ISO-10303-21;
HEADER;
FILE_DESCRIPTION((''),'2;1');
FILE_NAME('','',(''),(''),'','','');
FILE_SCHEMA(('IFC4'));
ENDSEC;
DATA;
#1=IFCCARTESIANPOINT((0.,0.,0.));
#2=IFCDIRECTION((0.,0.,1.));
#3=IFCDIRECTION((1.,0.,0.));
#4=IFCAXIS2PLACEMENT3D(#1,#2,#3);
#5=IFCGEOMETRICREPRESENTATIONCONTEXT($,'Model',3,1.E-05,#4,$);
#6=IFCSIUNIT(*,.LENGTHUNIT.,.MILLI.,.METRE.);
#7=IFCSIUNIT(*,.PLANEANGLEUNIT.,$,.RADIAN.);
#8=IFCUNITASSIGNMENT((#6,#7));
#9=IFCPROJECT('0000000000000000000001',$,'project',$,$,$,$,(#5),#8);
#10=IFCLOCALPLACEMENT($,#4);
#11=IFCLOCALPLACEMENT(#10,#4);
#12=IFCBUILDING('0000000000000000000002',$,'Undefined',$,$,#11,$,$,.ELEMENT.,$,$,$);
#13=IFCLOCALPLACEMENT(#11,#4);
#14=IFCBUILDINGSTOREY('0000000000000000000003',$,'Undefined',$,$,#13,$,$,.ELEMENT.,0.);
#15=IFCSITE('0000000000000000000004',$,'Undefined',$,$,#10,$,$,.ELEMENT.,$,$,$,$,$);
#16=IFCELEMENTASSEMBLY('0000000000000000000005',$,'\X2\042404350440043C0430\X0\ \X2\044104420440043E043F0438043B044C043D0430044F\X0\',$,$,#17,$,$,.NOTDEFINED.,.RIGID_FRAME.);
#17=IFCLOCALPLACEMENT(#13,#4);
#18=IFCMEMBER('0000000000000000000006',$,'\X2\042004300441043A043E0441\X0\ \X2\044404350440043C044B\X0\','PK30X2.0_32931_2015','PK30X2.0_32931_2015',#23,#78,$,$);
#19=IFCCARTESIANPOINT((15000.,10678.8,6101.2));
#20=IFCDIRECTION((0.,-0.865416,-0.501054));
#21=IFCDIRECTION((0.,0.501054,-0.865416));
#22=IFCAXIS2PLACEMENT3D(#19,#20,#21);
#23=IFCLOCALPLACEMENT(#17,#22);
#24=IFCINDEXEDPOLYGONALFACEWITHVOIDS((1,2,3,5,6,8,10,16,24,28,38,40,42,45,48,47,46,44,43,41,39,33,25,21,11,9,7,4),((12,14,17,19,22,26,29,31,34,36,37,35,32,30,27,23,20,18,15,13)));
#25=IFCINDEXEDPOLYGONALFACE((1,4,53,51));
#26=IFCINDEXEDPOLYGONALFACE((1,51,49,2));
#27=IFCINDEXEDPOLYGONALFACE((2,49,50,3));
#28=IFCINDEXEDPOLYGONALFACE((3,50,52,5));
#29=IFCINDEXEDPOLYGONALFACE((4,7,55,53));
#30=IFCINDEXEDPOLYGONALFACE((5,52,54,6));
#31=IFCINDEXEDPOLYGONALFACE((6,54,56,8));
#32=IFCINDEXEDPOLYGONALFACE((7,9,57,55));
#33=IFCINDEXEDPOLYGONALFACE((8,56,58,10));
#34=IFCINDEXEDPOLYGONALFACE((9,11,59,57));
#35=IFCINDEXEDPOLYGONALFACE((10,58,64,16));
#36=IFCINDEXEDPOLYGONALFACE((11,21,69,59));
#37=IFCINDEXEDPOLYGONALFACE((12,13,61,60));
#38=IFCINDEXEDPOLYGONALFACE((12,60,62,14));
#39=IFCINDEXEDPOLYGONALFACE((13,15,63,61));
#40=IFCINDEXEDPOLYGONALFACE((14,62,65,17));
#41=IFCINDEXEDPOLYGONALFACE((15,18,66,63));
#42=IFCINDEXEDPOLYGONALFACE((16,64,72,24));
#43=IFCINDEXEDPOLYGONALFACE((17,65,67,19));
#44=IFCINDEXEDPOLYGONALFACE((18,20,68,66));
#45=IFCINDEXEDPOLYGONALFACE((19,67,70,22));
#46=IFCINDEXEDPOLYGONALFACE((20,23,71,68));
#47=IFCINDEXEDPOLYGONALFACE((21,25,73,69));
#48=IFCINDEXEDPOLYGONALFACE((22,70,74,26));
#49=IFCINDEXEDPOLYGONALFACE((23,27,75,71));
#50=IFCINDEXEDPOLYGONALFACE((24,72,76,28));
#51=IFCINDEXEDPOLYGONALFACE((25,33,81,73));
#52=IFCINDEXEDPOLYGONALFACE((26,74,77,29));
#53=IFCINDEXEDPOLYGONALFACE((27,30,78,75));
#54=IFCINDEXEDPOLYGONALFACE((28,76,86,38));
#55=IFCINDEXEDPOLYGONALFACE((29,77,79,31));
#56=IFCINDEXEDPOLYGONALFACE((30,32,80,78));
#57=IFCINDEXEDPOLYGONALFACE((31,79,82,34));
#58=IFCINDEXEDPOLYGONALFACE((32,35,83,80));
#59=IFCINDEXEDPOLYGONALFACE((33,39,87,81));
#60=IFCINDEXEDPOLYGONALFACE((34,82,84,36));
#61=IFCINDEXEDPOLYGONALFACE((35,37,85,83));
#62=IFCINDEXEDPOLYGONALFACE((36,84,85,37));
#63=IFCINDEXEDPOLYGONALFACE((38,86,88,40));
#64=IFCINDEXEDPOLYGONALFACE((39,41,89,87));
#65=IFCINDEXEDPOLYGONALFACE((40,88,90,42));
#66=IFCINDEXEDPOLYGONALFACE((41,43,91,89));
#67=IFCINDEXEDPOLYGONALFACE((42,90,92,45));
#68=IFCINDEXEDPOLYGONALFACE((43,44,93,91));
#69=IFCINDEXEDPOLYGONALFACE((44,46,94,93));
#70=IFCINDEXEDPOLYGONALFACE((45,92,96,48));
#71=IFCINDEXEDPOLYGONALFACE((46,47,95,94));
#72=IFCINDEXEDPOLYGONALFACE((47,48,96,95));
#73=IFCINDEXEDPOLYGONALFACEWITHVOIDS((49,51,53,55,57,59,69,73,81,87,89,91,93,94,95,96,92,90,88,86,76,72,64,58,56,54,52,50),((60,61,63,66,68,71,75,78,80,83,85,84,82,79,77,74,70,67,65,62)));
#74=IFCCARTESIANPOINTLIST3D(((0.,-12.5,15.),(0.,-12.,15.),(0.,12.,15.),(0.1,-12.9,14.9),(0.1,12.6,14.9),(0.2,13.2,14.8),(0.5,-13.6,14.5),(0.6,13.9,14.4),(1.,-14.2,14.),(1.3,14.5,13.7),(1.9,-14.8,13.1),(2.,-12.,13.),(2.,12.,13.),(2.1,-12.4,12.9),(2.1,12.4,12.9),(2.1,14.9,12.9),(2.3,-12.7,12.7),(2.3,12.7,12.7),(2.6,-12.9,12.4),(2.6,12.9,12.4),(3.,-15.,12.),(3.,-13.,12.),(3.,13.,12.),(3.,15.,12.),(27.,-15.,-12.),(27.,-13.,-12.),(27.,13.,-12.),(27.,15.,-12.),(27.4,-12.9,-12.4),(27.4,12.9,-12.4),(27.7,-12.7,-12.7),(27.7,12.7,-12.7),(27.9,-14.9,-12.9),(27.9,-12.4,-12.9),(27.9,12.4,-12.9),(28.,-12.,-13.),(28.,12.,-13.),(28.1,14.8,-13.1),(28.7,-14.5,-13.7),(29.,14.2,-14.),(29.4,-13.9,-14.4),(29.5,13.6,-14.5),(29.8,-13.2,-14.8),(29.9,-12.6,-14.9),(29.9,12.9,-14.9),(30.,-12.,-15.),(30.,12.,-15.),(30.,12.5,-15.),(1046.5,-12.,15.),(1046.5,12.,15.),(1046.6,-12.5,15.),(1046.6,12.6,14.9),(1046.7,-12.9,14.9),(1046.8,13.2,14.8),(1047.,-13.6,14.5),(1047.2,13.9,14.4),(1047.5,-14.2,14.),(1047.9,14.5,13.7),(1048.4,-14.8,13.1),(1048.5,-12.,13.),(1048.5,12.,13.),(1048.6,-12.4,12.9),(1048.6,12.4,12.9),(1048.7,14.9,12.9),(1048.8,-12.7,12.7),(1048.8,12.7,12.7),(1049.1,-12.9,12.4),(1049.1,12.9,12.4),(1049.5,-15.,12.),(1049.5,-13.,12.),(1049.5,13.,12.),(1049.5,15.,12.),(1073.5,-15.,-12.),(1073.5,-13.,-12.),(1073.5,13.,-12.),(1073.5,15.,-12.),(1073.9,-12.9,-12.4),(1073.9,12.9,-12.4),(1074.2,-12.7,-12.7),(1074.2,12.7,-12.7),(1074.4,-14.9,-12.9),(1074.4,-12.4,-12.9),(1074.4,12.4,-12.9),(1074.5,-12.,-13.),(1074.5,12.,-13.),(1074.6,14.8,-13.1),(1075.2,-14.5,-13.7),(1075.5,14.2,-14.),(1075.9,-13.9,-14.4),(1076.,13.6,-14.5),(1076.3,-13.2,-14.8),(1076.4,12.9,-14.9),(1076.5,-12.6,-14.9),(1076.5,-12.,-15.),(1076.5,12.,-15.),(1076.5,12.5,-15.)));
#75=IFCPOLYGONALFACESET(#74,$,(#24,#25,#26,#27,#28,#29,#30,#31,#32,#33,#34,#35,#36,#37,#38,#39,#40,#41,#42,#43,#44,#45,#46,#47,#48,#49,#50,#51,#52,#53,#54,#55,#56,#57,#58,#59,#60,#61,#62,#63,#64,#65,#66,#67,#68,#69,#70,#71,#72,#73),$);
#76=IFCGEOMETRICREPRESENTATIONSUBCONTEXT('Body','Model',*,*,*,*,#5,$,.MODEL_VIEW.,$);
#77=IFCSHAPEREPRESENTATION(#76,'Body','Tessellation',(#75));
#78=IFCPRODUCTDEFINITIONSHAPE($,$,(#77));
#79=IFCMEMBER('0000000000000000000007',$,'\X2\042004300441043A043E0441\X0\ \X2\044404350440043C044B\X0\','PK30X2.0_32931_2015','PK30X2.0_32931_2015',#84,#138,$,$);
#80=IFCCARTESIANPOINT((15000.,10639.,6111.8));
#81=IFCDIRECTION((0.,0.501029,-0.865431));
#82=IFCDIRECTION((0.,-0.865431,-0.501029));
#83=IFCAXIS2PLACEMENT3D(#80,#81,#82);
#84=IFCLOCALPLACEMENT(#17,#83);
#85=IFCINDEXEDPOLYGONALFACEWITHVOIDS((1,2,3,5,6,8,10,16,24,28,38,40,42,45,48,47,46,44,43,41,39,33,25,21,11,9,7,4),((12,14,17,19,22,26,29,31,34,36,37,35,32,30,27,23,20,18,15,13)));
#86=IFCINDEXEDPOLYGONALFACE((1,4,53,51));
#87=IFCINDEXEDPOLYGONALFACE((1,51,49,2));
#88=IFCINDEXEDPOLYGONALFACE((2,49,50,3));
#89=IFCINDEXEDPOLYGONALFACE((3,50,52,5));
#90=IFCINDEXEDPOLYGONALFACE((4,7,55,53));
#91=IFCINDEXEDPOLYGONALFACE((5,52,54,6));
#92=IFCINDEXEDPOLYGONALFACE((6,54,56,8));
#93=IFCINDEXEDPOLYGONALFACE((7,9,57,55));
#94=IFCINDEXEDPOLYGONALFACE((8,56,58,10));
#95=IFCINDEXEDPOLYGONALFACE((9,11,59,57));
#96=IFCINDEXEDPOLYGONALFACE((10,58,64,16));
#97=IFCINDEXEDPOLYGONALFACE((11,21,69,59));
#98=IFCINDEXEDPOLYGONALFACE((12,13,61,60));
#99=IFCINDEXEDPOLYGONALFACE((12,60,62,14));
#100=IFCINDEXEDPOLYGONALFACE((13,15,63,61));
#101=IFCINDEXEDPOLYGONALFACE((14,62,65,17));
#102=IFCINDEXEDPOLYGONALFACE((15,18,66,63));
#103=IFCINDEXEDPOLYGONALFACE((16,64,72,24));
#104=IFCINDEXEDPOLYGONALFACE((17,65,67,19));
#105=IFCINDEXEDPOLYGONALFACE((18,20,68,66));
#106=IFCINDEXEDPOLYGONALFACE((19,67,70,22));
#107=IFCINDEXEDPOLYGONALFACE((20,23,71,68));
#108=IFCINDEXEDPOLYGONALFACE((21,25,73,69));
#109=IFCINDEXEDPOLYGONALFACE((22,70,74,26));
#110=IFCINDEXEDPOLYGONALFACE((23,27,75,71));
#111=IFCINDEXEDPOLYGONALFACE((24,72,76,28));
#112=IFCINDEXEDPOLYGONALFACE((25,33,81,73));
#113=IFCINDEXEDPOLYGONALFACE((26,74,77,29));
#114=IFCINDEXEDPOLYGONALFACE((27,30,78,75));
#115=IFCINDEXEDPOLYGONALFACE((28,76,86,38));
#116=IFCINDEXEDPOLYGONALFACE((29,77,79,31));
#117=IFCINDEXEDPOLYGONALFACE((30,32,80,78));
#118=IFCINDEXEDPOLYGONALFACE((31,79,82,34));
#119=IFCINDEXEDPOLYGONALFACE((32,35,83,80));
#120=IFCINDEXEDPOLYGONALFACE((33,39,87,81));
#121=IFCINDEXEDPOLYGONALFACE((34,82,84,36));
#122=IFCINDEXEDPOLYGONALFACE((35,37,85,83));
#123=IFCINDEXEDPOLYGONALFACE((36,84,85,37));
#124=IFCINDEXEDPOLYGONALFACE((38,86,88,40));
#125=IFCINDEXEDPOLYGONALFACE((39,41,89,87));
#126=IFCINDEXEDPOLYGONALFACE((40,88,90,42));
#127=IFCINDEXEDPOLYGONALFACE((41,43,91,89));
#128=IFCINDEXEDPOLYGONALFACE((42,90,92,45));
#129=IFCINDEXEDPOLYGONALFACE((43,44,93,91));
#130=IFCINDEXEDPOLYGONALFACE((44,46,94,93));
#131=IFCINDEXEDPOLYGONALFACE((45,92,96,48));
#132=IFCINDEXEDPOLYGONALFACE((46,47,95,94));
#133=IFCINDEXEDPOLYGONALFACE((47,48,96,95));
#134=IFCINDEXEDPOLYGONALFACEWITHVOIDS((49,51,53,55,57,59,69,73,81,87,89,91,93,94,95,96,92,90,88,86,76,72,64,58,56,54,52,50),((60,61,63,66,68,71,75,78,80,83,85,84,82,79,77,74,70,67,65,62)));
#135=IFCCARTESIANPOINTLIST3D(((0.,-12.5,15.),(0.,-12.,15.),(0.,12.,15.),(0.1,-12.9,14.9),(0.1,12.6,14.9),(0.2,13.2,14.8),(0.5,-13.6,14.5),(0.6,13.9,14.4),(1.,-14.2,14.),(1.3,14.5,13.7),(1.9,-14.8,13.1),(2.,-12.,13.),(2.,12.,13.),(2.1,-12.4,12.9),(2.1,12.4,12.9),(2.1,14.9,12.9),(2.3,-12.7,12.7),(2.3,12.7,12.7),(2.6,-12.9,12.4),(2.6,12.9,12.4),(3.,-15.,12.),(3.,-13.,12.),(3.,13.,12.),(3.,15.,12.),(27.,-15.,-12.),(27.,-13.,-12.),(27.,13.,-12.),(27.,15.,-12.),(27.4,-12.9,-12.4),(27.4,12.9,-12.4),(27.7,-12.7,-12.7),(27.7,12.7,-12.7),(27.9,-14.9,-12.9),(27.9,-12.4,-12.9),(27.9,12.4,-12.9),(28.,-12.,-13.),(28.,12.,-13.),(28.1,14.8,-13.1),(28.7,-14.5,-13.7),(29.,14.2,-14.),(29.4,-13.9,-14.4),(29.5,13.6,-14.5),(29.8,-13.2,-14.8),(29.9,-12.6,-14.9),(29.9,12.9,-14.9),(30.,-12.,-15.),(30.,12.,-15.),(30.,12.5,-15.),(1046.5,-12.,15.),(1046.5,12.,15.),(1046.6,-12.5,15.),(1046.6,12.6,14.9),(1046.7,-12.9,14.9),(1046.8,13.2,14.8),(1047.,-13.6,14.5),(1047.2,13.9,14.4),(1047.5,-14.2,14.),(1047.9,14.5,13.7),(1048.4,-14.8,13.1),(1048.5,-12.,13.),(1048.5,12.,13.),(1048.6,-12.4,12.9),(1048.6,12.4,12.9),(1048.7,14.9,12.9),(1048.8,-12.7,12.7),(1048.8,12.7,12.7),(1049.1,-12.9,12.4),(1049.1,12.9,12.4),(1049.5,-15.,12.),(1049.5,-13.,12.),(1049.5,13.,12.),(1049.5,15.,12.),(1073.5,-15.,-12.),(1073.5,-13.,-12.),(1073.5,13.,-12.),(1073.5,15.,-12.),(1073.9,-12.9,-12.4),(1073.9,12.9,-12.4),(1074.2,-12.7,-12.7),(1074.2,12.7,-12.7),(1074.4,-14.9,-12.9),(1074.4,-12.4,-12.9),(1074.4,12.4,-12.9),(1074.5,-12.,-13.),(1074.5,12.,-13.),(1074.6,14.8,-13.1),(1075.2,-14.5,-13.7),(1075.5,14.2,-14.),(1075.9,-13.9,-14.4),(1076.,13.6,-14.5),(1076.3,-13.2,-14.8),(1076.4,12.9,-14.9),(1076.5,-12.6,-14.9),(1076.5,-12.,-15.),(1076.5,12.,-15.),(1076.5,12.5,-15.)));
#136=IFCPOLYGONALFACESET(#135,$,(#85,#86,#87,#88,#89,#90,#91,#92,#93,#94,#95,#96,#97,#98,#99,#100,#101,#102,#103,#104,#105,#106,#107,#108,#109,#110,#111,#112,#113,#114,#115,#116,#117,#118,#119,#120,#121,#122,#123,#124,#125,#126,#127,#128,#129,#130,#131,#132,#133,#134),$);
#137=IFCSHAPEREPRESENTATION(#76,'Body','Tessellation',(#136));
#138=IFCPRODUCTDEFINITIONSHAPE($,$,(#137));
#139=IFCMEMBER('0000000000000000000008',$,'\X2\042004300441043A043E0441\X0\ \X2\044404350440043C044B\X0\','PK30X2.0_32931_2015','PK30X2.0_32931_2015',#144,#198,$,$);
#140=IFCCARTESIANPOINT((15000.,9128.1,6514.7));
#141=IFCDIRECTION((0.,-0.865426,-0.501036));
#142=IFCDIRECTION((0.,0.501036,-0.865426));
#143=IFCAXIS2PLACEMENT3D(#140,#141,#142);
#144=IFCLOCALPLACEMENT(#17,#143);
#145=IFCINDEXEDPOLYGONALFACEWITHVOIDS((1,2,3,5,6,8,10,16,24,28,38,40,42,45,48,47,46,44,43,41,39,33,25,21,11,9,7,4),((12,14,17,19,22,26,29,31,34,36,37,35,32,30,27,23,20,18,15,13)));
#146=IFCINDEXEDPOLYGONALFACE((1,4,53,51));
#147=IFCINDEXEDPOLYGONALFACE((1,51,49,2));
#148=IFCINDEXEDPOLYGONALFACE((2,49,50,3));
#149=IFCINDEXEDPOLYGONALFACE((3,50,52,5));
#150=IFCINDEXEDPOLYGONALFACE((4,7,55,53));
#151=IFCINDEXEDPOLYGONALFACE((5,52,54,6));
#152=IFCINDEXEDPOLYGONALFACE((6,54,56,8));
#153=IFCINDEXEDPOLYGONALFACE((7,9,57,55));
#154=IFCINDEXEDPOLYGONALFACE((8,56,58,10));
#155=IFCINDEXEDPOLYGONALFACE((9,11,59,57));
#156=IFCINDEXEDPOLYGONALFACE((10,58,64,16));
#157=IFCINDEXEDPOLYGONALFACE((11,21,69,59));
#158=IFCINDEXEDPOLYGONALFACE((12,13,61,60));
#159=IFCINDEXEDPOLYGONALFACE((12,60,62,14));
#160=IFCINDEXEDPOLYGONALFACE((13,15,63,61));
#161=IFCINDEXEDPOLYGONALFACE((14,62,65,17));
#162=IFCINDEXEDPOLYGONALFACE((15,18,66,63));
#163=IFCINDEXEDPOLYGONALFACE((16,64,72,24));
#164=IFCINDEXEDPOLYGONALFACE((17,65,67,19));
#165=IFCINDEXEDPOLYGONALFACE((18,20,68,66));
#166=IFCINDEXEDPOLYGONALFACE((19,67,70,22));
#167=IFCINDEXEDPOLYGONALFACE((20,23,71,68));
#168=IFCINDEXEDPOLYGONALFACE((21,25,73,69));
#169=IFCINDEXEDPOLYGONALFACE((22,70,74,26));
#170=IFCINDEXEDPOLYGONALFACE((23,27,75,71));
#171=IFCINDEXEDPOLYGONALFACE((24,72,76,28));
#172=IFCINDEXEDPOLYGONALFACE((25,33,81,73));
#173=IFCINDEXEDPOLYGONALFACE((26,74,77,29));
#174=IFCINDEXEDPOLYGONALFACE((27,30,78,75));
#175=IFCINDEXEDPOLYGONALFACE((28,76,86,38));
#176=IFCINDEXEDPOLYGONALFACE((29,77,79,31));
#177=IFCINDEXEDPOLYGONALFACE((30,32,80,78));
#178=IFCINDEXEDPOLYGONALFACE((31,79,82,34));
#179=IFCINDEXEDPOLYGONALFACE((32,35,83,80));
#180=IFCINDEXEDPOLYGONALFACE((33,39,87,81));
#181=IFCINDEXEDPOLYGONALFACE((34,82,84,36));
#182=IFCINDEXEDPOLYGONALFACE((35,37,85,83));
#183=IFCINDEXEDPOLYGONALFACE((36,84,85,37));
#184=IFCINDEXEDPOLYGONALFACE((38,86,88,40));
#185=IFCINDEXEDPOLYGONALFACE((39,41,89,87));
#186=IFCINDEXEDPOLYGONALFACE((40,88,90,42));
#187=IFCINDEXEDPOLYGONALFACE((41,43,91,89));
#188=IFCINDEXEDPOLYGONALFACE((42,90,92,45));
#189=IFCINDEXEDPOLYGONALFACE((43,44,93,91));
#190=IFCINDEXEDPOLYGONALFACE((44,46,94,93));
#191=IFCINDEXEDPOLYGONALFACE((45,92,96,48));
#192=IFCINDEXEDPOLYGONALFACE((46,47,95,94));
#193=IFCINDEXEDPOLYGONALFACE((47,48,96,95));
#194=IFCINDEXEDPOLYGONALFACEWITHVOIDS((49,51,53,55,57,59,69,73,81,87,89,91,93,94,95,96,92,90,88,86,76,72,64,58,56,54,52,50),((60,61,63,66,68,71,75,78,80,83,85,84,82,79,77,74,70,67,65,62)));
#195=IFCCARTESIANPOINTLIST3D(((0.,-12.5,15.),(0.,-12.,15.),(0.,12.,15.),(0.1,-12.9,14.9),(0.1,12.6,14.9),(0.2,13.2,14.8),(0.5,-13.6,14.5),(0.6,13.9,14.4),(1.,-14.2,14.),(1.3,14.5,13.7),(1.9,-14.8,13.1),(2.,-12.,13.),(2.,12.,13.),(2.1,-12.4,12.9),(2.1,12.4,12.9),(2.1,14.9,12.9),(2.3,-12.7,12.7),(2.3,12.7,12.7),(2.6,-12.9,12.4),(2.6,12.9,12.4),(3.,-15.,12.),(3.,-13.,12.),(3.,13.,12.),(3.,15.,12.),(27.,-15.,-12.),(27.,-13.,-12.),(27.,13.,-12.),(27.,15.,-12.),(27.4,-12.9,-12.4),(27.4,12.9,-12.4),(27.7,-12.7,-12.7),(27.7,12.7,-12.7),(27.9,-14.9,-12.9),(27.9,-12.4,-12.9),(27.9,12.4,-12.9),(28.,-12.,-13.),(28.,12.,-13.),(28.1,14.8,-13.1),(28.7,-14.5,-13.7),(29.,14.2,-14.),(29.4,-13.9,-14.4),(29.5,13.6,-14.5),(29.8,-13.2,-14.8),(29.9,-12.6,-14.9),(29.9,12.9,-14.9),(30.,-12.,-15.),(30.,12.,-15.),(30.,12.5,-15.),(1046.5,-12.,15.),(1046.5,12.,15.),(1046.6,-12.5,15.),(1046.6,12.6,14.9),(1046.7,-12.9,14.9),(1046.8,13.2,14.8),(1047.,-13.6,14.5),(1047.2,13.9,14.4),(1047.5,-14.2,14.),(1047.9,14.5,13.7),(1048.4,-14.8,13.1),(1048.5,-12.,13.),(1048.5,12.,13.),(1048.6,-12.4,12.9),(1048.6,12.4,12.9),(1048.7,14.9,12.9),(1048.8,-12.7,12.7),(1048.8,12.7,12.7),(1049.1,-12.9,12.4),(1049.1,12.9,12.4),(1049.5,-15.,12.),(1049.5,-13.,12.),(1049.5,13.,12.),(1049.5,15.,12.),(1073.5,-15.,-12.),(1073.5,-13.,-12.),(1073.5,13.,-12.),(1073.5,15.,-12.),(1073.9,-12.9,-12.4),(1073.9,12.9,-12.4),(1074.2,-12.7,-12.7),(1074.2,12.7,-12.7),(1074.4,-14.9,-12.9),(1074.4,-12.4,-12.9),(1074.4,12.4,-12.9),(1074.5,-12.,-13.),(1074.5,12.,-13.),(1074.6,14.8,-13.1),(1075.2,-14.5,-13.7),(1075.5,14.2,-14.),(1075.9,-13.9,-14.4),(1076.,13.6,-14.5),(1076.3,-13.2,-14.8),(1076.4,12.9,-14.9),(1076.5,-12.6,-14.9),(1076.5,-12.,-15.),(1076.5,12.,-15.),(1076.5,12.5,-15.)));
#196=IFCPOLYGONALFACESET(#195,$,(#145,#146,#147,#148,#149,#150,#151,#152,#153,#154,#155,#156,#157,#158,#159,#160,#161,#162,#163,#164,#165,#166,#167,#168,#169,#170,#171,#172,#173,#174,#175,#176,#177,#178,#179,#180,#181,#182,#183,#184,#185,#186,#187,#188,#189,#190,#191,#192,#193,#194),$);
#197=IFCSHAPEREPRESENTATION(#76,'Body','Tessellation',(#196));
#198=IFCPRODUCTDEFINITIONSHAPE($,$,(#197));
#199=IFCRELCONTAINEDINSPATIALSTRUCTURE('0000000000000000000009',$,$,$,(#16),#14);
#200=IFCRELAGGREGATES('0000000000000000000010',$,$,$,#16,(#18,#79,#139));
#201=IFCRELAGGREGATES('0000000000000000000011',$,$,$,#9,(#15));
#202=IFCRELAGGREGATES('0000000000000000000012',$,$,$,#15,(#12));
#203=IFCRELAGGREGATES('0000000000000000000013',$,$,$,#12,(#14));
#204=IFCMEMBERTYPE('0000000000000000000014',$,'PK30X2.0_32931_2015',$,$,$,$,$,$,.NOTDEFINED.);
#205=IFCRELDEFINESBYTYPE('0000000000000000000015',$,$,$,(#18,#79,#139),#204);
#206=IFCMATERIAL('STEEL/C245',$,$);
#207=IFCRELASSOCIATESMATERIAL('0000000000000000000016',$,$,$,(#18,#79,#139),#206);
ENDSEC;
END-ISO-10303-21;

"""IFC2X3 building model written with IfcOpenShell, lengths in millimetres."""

from ifc_helpers import new_model, si_unit, frame, origin_with_axes, origin_2d_with_axis, place, context, subcontext, project, spatial, hollow_rectangle, extrude, clip, halfspace, material, type_object, element, aggregate, save


model = new_model("IFC2X3")

# Units and contexts
model_context = context("Model", 3, precision=1e-05, world=origin_with_axes())
body_context = subcontext(model_context, "Body", "Model", "MODEL_VIEW")
ifc_project = project(units=[si_unit("LENGTHUNIT", "METRE", prefix="MILLI"), si_unit("PLANEANGLEUNIT", "RADIAN")], contexts=[model_context])

# Site, building, storey
site_placement = place(None, origin_with_axes())
site = spatial("IfcSite", under=ifc_project, at=site_placement, Name="Undefined", CompositionType="ELEMENT")
building_placement = place(site_placement, origin_with_axes())
building = spatial("IfcBuilding", under=site, at=building_placement, Name="Undefined", CompositionType="ELEMENT")
storey_placement = place(building_placement, origin_with_axes())
storey = spatial("IfcBuildingStorey", under=building, at=storey_placement, Name="Undefined", CompositionType="ELEMENT", Elevation=0.0)

# Element assembly
assembly_1_placement = place(storey_placement, origin_with_axes())
assembly_1 = element("IfcElementAssembly", 1, at=assembly_1_placement, inside=storey, Name="Ферма стропильная", AssemblyPlace="NOTDEFINED", PredefinedType="RIGID_FRAME")
ifc_material_1 = material(Name="STEEL/C245")

# Members
member_type = type_object("IfcMemberType", Name="PK30X2.0_32931_2015", PredefinedType="NOTDEFINED")
member_1_placement = place(assembly_1_placement, frame((15000.0, 10678.8, 6101.2), z_axis=(0.0, -0.865416, -0.501054), x_axis=(0.0, 0.501054, -0.865416)))
member_1 = element("IfcMember", 2, at=member_1_placement, type_object=member_type, material=ifc_material_1, Name="Раскос фермы", Description="PK30X2.0_32931_2015", ObjectType="PK30X2.0_32931_2015", context=body_context, shape_type="Clipping", body=[
    clip(clip(extrude(hollow_rectangle(XDim=30.0, YDim=30.0, WallThickness=2.0, InnerFilletRadius=1.0, OuterFilletRadius=3.0, at=origin_2d_with_axis()), frame((1091.8, 0.0, 0.0), z_axis=(-1.0, 0.0, 0.0), x_axis=(0.0, -1.0, 0.0)), (0.0, 0.0, 1.0), 1107.1), halfspace(frame((1060.0, 0.0, 1.5), z_axis=(-0.707107, 0.0, -0.707107), x_axis=(0.707107, 0.0, -0.707107)), True)), halfspace(frame((34.5, 0.0, -19.5), z_axis=(-0.707107, 0.0, -0.707107), x_axis=(0.707107, 0.0, -0.707107)), False)),
])
member_2_placement = place(assembly_1_placement, frame((15000.0, 10639.0, 6111.8), z_axis=(0.0, 0.501029, -0.865431), x_axis=(0.0, -0.865431, -0.501029)))
member_2 = element("IfcMember", 3, at=member_2_placement, type_object=member_type, material=ifc_material_1, Name="Раскос фермы", Description="PK30X2.0_32931_2015", ObjectType="PK30X2.0_32931_2015", context=body_context, shape_type="Clipping", body=[
    clip(clip(extrude(hollow_rectangle(XDim=30.0, YDim=30.0, WallThickness=2.0, InnerFilletRadius=1.0, OuterFilletRadius=3.0, at=origin_2d_with_axis()), frame((1102.9, 0.0, 0.0), z_axis=(-1.0, 0.0, 0.0), x_axis=(0.0, -1.0, 0.0)), (0.0, 0.0, 1.0), 1129.2), halfspace(frame((1060.0, 0.0, 1.5), z_axis=(-0.707107, 0.0, -0.707107), x_axis=(0.707107, 0.0, -0.707107)), True)), halfspace(frame((34.5, 0.0, -19.5), z_axis=(-0.707107, 0.0, -0.707107), x_axis=(0.707107, 0.0, -0.707107)), False)),
])
member_3_placement = place(assembly_1_placement, frame((15000.0, 9128.1, 6514.7), z_axis=(0.0, -0.865426, -0.501036), x_axis=(0.0, 0.501036, -0.865426)))
member_3 = element("IfcMember", 4, at=member_3_placement, type_object=member_type, material=ifc_material_1, Name="Раскос фермы", Description="PK30X2.0_32931_2015", ObjectType="PK30X2.0_32931_2015", context=body_context, shape_type="Clipping", body=[
    clip(clip(extrude(hollow_rectangle(XDim=30.0, YDim=30.0, WallThickness=2.0, InnerFilletRadius=1.0, OuterFilletRadius=3.0, at=origin_2d_with_axis()), frame((1091.8, 0.0, 0.0), z_axis=(-1.0, 0.0, 0.0), x_axis=(0.0, -1.0, 0.0)), (0.0, 0.0, 1.0), 1107.1), halfspace(frame((1060.0, 0.0, 1.5), z_axis=(-0.707107, 0.0, -0.707107), x_axis=(0.707107, 0.0, -0.707107)), True)), halfspace(frame((34.5, 0.0, -19.5), z_axis=(-0.707107, 0.0, -0.707107), x_axis=(0.707107, 0.0, -0.707107)), False)),
])
aggregate(assembly_1, [member_1, member_2, member_3])

save(model, "model.ifc")
